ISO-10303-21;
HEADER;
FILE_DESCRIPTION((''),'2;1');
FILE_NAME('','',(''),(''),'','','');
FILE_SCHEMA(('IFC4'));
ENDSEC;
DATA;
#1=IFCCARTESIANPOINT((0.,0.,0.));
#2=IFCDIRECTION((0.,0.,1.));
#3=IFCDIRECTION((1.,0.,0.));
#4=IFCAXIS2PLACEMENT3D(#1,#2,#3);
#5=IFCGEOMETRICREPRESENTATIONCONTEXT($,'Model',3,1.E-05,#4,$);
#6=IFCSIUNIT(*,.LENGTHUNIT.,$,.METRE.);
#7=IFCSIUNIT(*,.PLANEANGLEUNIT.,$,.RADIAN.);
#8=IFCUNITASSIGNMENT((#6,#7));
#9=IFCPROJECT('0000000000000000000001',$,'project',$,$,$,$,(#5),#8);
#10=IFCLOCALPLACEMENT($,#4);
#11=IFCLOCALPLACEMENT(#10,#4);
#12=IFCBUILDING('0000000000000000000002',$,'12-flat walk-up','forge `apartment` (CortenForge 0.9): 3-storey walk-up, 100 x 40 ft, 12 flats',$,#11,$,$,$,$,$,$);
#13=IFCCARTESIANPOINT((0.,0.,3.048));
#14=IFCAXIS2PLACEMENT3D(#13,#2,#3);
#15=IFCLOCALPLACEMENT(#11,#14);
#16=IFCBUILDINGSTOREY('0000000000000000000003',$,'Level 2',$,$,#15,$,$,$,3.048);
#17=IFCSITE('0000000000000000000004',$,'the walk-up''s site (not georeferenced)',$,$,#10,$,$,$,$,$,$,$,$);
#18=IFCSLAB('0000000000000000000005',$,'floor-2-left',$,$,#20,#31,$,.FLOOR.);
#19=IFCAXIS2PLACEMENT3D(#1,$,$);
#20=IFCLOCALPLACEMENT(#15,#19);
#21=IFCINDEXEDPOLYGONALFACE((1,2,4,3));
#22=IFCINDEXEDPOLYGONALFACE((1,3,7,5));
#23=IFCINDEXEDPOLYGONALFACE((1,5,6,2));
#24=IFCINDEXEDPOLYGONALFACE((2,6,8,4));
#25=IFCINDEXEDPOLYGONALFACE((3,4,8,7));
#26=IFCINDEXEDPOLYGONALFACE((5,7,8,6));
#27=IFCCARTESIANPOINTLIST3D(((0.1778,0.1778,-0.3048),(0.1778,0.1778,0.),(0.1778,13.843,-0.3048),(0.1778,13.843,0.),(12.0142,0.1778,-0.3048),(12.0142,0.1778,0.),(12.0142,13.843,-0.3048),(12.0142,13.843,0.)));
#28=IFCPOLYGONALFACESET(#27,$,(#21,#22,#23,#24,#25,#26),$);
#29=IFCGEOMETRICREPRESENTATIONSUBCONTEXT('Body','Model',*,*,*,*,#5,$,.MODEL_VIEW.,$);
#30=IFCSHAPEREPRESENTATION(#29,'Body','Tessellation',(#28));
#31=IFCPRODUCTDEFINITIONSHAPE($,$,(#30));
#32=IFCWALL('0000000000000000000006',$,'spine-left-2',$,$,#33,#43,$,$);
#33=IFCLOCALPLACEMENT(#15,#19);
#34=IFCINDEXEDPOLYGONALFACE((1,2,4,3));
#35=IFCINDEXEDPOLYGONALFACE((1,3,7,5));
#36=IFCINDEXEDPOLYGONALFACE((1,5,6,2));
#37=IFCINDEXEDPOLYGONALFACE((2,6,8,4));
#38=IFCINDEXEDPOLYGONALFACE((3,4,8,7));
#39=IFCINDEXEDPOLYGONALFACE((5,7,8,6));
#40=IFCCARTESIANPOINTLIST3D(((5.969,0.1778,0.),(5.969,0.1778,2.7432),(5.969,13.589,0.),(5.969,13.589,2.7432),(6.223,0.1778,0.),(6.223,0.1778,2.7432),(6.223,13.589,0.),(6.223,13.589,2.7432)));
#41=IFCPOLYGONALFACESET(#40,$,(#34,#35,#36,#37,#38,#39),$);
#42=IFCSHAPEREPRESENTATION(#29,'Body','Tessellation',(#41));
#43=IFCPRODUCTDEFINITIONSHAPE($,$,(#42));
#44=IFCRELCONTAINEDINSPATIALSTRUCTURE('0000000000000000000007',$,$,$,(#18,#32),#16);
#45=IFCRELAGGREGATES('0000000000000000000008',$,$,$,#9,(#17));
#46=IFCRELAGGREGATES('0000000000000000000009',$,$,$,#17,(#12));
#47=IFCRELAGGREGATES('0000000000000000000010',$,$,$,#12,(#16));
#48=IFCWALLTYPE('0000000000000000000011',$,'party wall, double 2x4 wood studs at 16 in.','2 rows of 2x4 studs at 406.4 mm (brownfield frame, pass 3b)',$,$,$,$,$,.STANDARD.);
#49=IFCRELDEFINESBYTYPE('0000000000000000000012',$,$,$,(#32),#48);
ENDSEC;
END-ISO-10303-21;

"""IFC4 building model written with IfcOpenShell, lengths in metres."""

from ifc_helpers import new_model, si_unit, frame, frame_2d, origin, origin_with_axes, place, context, subcontext, project, spatial, rectangle, extrude, type_object, element, save


model = new_model("IFC4")

# Units and contexts
model_context = context("Model", 3, precision=1e-05, world=origin_with_axes())
body_context = subcontext(model_context, "Body", "Model", "MODEL_VIEW")
ifc_project = project(units=[si_unit("LENGTHUNIT", "METRE"), si_unit("PLANEANGLEUNIT", "RADIAN")], contexts=[model_context])

# Site, building, storey
site_placement = place(None, origin_with_axes())
site = spatial("IfcSite", under=ifc_project, at=site_placement, Name="the walk-up's site (not georeferenced)")
building_placement = place(site_placement, origin_with_axes())
building = spatial("IfcBuilding", under=site, at=building_placement, Name="12-flat walk-up", Description="forge `apartment` (CortenForge 0.9): 3-storey walk-up, 100 x 40 ft, 12 flats")
storey_placement = place(building_placement, frame((0.0, 0.0, 3.048), z_axis=(0.0, 0.0, 1.0), x_axis=(1.0, 0.0, 0.0)))
storey = spatial("IfcBuildingStorey", under=building, at=storey_placement, Name="Level 2", Elevation=3.048)

# Slab
slab_placement = place(storey_placement, frame((0.1778, 0.1778, -0.3048), z_axis=(0.0, 0.0, 1.0), x_axis=(1.0, 0.0, 0.0)))
element("IfcSlab", 1, at=slab_placement, inside=storey, Name="floor-2-left", PredefinedType="FLOOR", context=body_context, shape_type="SweptSolid", body=[
    extrude(rectangle(XDim=11.8364, YDim=13.6652, at=frame_2d((5.9182, 6.8326))), origin(), (0.0, 0.0, 1.0), 0.3048),
])

# Wall
wall_type_1 = type_object("IfcWallType", Name="party wall, double 2x4 wood studs at 16 in.", Description="2 rows of 2x4 studs at 406.4 mm (brownfield frame, pass 3b)", PredefinedType="STANDARD")
wall_1_placement = place(storey_placement, frame((5.969, 0.1778, 0.0), z_axis=(0.0, 0.0, 1.0), x_axis=(1.0, 0.0, 0.0)))
element("IfcWall", 2, at=wall_1_placement, inside=storey, type_object=wall_type_1, Name="spine-left-2", context=body_context, shape_type="SweptSolid", body=[
    extrude(rectangle(XDim=0.254, YDim=13.4112, at=frame_2d((0.127, 6.7056))), origin(), (0.0, 0.0, 1.0), 2.7432),
])

save(model, "model.ifc")
